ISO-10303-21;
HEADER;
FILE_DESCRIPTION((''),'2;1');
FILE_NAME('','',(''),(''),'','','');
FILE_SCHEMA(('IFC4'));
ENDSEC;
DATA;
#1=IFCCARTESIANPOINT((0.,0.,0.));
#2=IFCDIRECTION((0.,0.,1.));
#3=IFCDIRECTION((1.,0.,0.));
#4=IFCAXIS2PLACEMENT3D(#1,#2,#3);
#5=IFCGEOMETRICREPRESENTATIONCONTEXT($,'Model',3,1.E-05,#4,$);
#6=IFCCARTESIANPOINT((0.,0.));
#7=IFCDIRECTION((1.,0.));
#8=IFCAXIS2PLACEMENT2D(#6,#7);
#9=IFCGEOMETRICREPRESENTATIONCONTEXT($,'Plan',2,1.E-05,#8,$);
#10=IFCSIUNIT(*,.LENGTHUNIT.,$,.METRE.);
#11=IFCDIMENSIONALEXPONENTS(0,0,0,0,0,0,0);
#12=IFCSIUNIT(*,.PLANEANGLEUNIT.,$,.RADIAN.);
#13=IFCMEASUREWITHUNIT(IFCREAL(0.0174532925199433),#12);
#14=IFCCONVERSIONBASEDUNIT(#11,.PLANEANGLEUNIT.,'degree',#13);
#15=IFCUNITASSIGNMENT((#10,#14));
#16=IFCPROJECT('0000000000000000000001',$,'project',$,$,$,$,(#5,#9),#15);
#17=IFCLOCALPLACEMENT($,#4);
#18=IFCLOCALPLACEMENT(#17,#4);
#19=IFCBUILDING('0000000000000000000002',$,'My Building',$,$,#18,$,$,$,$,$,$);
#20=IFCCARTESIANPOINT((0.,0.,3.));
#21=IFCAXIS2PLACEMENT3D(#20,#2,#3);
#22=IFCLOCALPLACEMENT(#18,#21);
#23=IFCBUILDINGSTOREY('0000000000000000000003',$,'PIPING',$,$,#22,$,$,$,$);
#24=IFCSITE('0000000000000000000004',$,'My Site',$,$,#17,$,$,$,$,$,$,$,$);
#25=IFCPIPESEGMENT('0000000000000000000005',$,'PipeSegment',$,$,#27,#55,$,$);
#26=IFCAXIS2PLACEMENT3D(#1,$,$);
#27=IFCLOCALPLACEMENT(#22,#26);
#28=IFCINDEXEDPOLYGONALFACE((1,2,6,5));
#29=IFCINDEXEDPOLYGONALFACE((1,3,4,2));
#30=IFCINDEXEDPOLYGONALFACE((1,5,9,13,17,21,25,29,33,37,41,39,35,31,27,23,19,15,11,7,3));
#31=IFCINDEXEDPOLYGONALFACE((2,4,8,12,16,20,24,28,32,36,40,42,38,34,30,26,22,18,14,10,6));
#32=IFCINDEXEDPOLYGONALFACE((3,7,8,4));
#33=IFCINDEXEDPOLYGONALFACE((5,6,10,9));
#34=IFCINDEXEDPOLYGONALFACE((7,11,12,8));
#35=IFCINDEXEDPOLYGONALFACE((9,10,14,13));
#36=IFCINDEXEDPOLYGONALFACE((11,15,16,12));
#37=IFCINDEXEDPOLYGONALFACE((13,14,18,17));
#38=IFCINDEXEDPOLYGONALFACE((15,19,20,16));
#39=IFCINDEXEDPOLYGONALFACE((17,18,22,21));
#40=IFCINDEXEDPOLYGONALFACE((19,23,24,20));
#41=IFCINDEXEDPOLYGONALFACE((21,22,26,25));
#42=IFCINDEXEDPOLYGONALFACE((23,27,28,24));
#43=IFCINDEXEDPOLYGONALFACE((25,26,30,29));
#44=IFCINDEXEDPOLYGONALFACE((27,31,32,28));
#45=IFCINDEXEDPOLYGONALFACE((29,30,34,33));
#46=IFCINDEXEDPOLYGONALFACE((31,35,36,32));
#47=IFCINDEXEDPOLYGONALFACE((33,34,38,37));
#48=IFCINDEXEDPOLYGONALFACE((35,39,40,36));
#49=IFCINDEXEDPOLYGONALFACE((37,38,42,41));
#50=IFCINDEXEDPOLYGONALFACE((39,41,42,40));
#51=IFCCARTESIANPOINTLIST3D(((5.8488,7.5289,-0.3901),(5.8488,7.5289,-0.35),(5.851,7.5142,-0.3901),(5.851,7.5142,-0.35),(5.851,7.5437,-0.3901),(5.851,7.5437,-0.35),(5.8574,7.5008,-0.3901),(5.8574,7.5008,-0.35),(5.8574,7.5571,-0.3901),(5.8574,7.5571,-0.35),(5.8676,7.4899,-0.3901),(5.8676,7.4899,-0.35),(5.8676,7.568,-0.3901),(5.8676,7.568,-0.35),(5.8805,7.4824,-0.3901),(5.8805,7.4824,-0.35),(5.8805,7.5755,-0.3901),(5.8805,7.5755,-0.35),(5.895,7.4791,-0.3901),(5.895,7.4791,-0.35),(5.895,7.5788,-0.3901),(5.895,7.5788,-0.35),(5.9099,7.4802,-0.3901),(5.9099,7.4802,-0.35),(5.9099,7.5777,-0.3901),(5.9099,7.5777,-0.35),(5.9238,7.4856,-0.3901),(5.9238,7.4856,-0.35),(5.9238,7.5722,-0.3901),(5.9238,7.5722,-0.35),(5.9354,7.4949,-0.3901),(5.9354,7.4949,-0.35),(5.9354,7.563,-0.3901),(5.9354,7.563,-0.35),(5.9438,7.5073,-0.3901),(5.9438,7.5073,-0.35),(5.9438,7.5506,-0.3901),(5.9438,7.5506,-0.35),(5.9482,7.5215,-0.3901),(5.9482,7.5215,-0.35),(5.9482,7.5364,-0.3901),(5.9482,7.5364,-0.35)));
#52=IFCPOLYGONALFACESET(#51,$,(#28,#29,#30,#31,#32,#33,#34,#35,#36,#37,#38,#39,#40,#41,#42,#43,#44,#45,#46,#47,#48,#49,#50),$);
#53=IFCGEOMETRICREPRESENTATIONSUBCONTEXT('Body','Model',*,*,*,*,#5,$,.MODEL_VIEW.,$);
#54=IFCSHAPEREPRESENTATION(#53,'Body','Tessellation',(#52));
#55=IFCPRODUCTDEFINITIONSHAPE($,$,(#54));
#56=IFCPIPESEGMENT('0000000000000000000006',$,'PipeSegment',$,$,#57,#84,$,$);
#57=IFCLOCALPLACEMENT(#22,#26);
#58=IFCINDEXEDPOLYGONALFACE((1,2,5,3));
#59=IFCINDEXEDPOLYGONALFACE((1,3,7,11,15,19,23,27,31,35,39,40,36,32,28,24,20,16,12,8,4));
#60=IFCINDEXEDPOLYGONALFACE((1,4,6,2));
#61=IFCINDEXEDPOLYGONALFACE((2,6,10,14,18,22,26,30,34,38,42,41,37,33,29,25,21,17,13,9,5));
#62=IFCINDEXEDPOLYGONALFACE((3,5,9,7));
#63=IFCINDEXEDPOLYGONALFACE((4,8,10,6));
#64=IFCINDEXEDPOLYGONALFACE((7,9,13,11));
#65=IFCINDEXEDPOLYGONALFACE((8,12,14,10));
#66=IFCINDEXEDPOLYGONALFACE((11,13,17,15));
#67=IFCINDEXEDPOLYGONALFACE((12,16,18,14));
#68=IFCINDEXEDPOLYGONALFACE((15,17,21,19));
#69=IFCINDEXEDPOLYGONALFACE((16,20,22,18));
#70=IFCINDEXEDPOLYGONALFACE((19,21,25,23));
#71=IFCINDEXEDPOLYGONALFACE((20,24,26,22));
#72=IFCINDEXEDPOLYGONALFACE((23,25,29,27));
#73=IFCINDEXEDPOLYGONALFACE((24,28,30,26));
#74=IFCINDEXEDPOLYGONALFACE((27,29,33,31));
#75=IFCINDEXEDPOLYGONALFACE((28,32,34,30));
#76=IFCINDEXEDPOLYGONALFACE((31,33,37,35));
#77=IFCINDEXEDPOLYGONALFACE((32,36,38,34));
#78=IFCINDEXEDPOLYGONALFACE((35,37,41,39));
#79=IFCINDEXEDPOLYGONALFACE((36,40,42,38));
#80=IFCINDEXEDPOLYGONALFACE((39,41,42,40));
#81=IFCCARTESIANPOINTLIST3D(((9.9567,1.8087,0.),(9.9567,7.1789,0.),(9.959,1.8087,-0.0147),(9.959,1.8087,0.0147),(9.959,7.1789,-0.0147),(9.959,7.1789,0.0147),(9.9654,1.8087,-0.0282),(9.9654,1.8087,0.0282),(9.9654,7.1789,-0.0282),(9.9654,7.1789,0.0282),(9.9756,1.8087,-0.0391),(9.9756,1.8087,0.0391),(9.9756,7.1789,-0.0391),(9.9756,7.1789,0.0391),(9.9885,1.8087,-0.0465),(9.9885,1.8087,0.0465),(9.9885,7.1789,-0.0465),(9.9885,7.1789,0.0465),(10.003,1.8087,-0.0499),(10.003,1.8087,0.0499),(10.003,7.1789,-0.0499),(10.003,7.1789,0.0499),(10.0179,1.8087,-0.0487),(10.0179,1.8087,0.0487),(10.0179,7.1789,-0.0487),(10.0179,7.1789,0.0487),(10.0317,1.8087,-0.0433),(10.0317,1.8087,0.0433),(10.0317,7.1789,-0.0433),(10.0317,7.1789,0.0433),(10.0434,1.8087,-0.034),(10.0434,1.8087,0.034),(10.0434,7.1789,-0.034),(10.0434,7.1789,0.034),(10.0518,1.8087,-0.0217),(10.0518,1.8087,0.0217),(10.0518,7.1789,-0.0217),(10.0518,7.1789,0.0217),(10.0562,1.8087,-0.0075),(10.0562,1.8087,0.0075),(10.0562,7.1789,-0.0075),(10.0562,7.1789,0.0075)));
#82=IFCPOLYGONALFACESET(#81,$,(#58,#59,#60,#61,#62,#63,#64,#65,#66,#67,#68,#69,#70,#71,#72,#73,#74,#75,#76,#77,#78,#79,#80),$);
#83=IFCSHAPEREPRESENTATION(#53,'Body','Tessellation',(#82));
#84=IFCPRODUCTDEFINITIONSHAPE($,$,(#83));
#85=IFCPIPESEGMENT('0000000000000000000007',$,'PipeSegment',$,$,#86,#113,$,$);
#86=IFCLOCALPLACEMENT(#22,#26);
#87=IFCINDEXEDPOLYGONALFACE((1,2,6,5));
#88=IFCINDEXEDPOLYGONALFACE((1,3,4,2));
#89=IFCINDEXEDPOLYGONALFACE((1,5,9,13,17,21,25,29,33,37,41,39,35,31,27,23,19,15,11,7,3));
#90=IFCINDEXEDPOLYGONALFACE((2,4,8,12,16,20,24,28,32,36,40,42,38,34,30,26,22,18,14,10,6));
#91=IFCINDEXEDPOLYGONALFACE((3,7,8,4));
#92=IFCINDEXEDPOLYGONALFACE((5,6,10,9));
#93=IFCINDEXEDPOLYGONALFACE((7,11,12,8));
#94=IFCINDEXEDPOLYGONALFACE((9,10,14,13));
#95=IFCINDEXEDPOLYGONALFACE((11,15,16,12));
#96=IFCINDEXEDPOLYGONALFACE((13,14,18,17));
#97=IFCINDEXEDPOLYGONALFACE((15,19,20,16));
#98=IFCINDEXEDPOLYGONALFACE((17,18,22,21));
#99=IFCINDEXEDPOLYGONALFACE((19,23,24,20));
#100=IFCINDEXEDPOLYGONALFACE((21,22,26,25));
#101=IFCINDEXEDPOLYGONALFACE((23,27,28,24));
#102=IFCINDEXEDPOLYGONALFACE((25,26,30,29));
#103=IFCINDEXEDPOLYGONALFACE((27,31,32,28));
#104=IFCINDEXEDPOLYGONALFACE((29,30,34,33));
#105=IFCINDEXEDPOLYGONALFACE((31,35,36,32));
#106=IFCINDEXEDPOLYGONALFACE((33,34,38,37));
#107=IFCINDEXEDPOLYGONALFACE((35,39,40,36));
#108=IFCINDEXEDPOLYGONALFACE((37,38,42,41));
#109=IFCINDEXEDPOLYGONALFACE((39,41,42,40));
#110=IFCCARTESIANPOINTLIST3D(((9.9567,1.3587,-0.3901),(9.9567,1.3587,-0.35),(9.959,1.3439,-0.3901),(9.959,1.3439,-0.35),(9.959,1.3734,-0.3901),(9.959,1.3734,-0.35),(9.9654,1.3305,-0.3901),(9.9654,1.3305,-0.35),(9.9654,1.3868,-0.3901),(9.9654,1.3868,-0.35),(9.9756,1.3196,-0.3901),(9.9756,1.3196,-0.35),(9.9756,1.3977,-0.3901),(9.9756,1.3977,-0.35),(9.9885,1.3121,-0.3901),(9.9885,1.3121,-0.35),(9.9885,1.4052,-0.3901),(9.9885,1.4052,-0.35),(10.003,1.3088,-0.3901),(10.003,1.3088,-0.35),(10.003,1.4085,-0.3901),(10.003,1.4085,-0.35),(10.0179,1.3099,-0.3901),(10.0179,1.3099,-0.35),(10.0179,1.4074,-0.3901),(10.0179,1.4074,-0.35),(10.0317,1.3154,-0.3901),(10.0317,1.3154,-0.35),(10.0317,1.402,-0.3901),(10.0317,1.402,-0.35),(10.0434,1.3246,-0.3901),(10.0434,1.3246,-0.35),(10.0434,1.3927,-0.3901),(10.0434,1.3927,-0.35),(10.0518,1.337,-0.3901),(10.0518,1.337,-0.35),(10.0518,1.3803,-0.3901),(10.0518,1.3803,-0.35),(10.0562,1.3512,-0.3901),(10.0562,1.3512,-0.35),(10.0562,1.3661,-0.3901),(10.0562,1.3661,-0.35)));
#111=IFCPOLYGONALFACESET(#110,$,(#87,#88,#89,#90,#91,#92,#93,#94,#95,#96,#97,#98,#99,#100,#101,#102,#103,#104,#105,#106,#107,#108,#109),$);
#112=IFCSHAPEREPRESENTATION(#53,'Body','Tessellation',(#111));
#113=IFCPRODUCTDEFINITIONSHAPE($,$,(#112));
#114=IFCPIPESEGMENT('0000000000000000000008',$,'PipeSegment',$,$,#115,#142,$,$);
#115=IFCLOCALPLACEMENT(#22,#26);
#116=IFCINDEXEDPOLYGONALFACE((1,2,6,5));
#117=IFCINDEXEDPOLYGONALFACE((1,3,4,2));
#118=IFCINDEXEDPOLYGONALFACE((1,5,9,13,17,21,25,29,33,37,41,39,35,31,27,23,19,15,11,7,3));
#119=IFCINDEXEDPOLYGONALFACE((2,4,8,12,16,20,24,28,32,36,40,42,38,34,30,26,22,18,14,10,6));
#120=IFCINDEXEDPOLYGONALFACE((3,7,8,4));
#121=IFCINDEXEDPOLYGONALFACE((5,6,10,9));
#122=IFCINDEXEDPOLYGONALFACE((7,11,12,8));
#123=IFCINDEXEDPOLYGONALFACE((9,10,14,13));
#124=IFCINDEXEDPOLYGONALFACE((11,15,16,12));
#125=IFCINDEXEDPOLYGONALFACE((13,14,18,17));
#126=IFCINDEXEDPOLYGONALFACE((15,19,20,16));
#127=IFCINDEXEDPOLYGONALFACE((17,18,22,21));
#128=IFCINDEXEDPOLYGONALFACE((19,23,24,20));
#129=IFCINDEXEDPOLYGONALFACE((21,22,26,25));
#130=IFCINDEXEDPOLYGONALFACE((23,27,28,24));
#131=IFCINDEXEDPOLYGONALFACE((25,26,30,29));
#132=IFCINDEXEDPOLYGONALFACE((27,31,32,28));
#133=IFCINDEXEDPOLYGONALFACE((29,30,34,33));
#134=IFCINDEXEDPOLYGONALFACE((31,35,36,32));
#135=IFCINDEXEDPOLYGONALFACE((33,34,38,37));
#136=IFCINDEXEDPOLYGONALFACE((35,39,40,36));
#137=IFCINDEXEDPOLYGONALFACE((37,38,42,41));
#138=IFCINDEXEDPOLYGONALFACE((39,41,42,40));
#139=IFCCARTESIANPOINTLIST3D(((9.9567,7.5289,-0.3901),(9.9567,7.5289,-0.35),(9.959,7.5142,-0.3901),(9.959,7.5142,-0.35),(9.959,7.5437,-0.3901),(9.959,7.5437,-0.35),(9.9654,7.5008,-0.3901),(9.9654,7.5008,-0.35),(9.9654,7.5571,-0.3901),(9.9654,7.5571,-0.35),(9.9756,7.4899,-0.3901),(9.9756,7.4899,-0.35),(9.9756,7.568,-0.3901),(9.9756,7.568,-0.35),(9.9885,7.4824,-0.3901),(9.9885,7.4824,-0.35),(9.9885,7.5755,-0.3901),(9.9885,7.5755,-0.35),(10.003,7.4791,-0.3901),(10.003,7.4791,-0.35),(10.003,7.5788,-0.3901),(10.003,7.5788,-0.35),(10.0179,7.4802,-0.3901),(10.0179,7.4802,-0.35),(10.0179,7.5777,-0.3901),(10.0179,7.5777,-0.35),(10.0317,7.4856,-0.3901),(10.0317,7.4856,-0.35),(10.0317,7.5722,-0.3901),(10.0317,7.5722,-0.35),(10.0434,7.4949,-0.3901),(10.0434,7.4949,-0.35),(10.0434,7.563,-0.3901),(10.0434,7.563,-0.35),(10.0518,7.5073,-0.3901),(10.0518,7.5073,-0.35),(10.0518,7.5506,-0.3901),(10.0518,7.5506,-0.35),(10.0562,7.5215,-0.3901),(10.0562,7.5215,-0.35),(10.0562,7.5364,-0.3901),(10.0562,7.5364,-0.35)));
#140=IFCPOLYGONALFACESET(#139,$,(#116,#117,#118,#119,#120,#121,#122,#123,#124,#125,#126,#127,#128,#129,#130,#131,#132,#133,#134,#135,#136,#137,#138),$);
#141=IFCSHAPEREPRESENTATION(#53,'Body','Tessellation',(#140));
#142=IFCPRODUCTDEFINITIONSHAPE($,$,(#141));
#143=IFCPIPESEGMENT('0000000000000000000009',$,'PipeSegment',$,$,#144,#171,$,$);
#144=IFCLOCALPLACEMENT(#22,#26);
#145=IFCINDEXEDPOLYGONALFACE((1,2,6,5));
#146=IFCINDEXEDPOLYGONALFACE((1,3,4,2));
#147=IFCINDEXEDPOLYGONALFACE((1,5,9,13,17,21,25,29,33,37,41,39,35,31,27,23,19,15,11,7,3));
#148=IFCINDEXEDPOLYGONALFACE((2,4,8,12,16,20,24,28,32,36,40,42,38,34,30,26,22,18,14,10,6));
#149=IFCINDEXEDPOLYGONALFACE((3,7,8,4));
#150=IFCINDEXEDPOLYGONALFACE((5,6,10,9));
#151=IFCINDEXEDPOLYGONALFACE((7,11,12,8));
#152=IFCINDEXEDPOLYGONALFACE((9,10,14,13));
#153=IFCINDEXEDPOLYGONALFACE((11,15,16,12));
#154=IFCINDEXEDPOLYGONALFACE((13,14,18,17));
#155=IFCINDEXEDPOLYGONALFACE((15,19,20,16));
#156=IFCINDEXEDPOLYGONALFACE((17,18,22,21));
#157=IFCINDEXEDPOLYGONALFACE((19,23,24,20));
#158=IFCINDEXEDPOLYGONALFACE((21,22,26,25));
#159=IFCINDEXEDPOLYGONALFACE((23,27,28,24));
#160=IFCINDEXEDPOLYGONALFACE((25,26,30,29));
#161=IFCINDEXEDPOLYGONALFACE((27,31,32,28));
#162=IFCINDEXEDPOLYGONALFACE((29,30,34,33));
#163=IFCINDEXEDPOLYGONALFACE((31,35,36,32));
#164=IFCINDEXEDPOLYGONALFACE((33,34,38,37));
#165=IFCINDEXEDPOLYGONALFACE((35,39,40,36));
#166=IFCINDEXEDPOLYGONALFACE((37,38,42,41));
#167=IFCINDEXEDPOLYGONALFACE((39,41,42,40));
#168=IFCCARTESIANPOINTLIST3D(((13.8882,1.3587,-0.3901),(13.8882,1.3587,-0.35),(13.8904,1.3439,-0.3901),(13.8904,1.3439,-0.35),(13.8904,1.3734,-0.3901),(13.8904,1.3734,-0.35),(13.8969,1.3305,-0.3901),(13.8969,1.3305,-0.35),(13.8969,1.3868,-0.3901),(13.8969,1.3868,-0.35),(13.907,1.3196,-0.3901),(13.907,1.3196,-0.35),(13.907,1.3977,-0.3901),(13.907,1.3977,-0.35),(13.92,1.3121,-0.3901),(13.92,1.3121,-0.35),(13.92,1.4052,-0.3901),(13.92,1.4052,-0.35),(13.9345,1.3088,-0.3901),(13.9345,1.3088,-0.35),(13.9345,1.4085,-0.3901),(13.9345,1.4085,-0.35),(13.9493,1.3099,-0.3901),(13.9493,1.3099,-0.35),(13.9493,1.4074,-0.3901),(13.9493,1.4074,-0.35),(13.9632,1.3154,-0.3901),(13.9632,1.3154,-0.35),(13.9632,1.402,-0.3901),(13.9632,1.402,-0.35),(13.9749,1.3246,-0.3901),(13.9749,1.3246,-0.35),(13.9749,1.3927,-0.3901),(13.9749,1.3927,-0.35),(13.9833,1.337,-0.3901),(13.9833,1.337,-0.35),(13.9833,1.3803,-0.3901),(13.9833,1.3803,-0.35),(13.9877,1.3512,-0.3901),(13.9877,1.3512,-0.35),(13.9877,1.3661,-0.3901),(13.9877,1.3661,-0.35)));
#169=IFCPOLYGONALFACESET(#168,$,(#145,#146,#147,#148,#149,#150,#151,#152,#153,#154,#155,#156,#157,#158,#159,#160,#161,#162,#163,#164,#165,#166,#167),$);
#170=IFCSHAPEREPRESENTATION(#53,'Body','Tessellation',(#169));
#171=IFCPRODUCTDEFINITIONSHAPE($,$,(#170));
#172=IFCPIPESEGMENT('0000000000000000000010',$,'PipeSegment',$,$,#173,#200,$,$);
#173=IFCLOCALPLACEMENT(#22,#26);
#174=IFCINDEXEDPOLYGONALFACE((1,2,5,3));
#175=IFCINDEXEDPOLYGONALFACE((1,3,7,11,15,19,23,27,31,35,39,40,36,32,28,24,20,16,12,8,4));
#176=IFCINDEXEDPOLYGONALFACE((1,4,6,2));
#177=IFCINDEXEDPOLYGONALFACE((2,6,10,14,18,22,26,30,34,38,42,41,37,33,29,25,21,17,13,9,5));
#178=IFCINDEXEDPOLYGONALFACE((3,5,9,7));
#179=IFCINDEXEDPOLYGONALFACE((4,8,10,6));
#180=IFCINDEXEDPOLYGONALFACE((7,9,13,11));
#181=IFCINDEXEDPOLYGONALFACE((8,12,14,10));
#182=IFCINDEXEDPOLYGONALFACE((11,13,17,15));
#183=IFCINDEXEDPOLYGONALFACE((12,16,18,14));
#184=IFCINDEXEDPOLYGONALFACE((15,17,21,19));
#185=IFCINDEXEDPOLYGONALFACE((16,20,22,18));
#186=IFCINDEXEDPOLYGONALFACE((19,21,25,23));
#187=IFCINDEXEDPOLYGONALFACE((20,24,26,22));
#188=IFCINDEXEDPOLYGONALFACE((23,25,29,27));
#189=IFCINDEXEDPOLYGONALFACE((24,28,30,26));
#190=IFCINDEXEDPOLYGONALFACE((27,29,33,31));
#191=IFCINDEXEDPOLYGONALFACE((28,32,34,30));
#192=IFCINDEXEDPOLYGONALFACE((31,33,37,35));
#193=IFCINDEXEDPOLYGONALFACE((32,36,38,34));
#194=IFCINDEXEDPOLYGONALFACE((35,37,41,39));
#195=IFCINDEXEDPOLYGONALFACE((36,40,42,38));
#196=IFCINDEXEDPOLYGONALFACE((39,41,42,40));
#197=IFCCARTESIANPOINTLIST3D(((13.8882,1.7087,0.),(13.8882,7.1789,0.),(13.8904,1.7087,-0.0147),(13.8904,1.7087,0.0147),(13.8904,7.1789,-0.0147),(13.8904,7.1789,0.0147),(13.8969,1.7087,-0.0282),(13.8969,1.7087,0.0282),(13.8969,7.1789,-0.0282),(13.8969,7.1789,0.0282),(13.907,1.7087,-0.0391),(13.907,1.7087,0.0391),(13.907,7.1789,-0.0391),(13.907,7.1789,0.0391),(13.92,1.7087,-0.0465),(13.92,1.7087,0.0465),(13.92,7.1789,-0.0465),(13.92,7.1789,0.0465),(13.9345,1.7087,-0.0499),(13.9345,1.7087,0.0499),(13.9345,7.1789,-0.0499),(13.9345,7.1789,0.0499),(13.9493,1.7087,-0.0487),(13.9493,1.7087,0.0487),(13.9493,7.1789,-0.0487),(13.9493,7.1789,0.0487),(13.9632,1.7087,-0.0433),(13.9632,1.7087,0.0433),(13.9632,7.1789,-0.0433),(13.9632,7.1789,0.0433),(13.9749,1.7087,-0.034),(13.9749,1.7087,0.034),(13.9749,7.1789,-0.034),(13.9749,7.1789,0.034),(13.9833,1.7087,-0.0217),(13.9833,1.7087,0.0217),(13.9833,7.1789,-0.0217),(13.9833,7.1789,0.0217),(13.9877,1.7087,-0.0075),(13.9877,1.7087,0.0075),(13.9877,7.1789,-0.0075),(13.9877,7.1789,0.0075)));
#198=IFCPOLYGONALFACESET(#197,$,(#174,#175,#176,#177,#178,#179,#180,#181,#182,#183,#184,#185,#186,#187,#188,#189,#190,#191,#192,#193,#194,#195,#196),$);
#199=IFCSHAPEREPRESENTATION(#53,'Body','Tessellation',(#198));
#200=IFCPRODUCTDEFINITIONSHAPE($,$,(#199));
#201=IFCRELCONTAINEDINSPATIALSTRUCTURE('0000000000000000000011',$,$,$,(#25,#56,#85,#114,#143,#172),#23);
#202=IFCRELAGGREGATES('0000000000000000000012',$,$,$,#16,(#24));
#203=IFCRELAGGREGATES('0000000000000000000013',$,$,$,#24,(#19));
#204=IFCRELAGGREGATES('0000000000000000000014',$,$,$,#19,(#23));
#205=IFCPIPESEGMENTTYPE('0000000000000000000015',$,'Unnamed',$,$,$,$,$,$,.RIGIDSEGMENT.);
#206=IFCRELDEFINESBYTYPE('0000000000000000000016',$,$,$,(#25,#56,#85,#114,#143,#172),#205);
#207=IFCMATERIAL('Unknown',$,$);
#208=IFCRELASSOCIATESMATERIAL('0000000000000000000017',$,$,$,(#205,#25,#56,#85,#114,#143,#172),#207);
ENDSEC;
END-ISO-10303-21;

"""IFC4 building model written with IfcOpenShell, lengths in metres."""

from ifc_helpers import new_model, entity, si_unit, converted_unit, frame, origin_with_axes, origin_2d_with_axis, place, context, subcontext, project, spatial, circle, extrude, material, material_profile, profile_set, profile_usage, type_object, element, save


model = new_model("IFC4")

# Units and contexts
model_context = context("Model", 3, precision=1e-05, world=origin_with_axes())
plan_context = context("Plan", 2, precision=1e-05, world=origin_2d_with_axis())
body_context = subcontext(model_context, "Body", "Model", "MODEL_VIEW")
ifc_project = project(units=[si_unit("LENGTHUNIT", "METRE"), converted_unit("PLANEANGLEUNIT", "degree", entity("IfcReal", 0.0174532925199433), si_unit("PLANEANGLEUNIT", "RADIAN"), dimensions=[0, 0, 0, 0, 0, 0, 0])], contexts=[model_context, plan_context])

# Site, building, storey
site_placement = place(None, origin_with_axes())
site = spatial("IfcSite", under=ifc_project, at=site_placement, Name="My Site")
building_placement = place(site_placement, origin_with_axes())
building = spatial("IfcBuilding", under=site, at=building_placement, Name="My Building")
storey_placement = place(building_placement, frame((0.0, 0.0, 3.0), z_axis=(0.0, 0.0, 1.0), x_axis=(1.0, 0.0, 0.0)))
storey = spatial("IfcBuildingStorey", under=building, at=storey_placement, Name="PIPING")

# Pipe segments
ifc_material = material(Name="Unknown")
ifc_material_profile_1 = material_profile(ifc_material, circle(Radius=0.05))
ifc_profile_set_1 = profile_set([ifc_material_profile_1])
pipe_segment_type = type_object("IfcPipeSegmentType", Name="Unnamed", PredefinedType="RIGIDSEGMENT", material=ifc_profile_set_1)
ifc_profile_usage_1 = profile_usage(ifc_profile_set_1, cardinal=5)
pipe_segment_1_placement = place(storey_placement, frame((5.8988, 7.5289, -0.35), z_axis=(0.0, 0.0, -1.0), x_axis=(-1.0, 0.0, 0.0)))
element("IfcPipeSegment", 1, at=pipe_segment_1_placement, inside=storey, type_object=pipe_segment_type, material=ifc_profile_usage_1, Name="PipeSegment", context=body_context, shape_type="SweptSolid", body=[
    extrude(circle(Radius=0.05), origin_with_axes(), (0.0, 0.0, 1.0), 0.0401),
])
ifc_profile_usage_2 = profile_usage(ifc_profile_set_1, cardinal=5)
pipe_segment_2_placement = place(storey_placement, frame((10.0067, 1.8087, 0.0), z_axis=(0.0, 1.0, 0.0), x_axis=(-1.0, 0.0, 0.0)))
element("IfcPipeSegment", 2, at=pipe_segment_2_placement, inside=storey, type_object=pipe_segment_type, material=ifc_profile_usage_2, Name="PipeSegment", context=body_context, shape_type="SweptSolid", body=[
    extrude(circle(Radius=0.05), origin_with_axes(), (0.0, 0.0, 1.0), 5.3703),
])
ifc_profile_usage_3 = profile_usage(ifc_profile_set_1, cardinal=5)
pipe_segment_3_placement = place(storey_placement, frame((10.0067, 1.3587, -0.35), z_axis=(0.0, 0.0, -1.0), x_axis=(-1.0, 0.0, 0.0)))
element("IfcPipeSegment", 3, at=pipe_segment_3_placement, inside=storey, type_object=pipe_segment_type, material=ifc_profile_usage_3, Name="PipeSegment", context=body_context, shape_type="SweptSolid", body=[
    extrude(circle(Radius=0.05), origin_with_axes(), (0.0, 0.0, 1.0), 0.0401),
])
ifc_profile_usage_4 = profile_usage(ifc_profile_set_1, cardinal=5)
pipe_segment_4_placement = place(storey_placement, frame((10.0067, 7.5289, -0.35), z_axis=(0.0, 0.0, -1.0), x_axis=(-1.0, 0.0, 0.0)))
element("IfcPipeSegment", 4, at=pipe_segment_4_placement, inside=storey, type_object=pipe_segment_type, material=ifc_profile_usage_4, Name="PipeSegment", context=body_context, shape_type="SweptSolid", body=[
    extrude(circle(Radius=0.05), origin_with_axes(), (0.0, 0.0, 1.0), 0.0401),
])
ifc_profile_usage_5 = profile_usage(ifc_profile_set_1, cardinal=5)
pipe_segment_5_placement = place(storey_placement, frame((13.9382, 1.3587, -0.35), z_axis=(0.0, 0.0, -1.0), x_axis=(-1.0, 0.0, 0.0)))
element("IfcPipeSegment", 5, at=pipe_segment_5_placement, inside=storey, type_object=pipe_segment_type, material=ifc_profile_usage_5, Name="PipeSegment", context=body_context, shape_type="SweptSolid", body=[
    extrude(circle(Radius=0.05), origin_with_axes(), (0.0, 0.0, 1.0), 0.0401),
])
ifc_profile_usage_6 = profile_usage(ifc_profile_set_1, cardinal=5)
pipe_segment_6_placement = place(storey_placement, frame((13.9382, 1.7087, 0.0), z_axis=(0.0, 1.0, 0.0), x_axis=(-1.0, 0.0, 0.0)))
element("IfcPipeSegment", 6, at=pipe_segment_6_placement, inside=storey, type_object=pipe_segment_type, material=ifc_profile_usage_6, Name="PipeSegment", context=body_context, shape_type="SweptSolid", body=[
    extrude(circle(Radius=0.05), origin_with_axes(), (0.0, 0.0, 1.0), 5.4703),
])

save(model, "model.ifc")
